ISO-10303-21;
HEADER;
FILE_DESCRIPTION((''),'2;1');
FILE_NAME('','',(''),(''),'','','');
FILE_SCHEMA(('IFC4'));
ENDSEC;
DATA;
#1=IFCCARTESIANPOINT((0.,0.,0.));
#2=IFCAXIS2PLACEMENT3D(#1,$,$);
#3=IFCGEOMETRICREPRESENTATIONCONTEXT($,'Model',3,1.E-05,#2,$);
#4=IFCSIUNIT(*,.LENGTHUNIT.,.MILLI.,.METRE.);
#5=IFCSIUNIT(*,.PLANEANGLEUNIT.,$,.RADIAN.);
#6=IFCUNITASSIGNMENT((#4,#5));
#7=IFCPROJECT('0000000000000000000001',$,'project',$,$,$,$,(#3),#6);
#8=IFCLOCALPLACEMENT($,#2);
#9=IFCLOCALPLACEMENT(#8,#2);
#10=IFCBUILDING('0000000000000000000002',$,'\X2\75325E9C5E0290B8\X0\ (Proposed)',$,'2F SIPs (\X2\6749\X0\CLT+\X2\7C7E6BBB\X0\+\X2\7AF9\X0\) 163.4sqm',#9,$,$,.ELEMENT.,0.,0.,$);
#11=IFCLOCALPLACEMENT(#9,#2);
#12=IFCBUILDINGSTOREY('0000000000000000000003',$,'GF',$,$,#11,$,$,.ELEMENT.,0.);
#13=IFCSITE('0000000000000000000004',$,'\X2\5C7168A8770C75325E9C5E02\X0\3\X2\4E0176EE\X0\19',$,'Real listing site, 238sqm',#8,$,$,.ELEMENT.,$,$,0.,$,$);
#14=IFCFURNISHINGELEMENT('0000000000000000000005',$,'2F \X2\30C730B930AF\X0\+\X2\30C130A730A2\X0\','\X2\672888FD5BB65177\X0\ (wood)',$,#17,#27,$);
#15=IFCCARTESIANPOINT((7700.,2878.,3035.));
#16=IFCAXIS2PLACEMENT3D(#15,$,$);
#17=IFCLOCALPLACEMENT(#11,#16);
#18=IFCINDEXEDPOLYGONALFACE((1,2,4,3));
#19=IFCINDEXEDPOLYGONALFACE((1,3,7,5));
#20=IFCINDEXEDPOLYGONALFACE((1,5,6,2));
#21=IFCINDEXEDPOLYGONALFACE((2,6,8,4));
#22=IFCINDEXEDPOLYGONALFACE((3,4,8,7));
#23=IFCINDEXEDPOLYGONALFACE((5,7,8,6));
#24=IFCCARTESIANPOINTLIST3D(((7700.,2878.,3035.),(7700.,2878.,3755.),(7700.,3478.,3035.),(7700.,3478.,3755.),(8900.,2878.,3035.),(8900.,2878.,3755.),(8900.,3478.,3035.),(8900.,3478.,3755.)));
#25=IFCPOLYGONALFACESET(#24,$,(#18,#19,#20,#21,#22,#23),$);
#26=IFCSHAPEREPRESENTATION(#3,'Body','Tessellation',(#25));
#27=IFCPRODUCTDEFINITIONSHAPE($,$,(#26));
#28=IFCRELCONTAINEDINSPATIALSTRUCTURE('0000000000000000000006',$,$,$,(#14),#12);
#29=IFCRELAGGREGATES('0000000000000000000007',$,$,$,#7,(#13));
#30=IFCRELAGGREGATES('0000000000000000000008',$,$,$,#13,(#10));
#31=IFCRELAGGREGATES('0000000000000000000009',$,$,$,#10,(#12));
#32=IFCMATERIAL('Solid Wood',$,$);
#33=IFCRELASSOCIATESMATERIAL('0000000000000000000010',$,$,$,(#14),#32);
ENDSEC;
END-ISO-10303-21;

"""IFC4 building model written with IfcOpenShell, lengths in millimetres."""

from ifc_helpers import new_model, si_unit, frame, frame_2d, origin, place, context, project, spatial, rectangle, extrude, material, element, save


model = new_model("IFC4")

# Units and contexts
model_context = context("Model", 3, precision=1e-05, world=origin())
ifc_project = project(units=[si_unit("LENGTHUNIT", "METRE", prefix="MILLI"), si_unit("PLANEANGLEUNIT", "RADIAN")], contexts=[model_context])

# Site, building, storey
site_placement = place(None, origin())
site = spatial("IfcSite", under=ifc_project, at=site_placement, Name="山梨県甲府市3丁目19", ObjectType="Real listing site, 238sqm", CompositionType="ELEMENT", RefElevation=0.0)
building_placement = place(site_placement, origin())
building = spatial("IfcBuilding", under=site, at=building_placement, Name="甲府市邸 (Proposed)", ObjectType="2F SIPs (杉CLT+籾殻+竹) 163.4sqm", CompositionType="ELEMENT", ElevationOfRefHeight=0.0, ElevationOfTerrain=0.0)
storey_placement = place(building_placement, origin())
storey = spatial("IfcBuildingStorey", under=building, at=storey_placement, Name="GF", CompositionType="ELEMENT", Elevation=0.0)

# Shared definitions
ifc_material_1 = material(Name="Solid Wood")

# Furnishing element
furnishing_1_placement = place(storey_placement, frame((7700.0, 2878.0, 3035.0)))
element("IfcFurnishingElement", 1, at=furnishing_1_placement, inside=storey, material=ifc_material_1, Name="2F デスク+チェア", Description="木製家具 (wood)", context=model_context, shape_type="SweptSolid", body=[
    extrude(rectangle(XDim=1200.0, YDim=600.0, at=frame_2d((600.0, 300.0))), frame((7700.0, 2878.0, 3035.0)), (0.0, 0.0, 1.0), 720.0),
])

save(model, "model.ifc")
